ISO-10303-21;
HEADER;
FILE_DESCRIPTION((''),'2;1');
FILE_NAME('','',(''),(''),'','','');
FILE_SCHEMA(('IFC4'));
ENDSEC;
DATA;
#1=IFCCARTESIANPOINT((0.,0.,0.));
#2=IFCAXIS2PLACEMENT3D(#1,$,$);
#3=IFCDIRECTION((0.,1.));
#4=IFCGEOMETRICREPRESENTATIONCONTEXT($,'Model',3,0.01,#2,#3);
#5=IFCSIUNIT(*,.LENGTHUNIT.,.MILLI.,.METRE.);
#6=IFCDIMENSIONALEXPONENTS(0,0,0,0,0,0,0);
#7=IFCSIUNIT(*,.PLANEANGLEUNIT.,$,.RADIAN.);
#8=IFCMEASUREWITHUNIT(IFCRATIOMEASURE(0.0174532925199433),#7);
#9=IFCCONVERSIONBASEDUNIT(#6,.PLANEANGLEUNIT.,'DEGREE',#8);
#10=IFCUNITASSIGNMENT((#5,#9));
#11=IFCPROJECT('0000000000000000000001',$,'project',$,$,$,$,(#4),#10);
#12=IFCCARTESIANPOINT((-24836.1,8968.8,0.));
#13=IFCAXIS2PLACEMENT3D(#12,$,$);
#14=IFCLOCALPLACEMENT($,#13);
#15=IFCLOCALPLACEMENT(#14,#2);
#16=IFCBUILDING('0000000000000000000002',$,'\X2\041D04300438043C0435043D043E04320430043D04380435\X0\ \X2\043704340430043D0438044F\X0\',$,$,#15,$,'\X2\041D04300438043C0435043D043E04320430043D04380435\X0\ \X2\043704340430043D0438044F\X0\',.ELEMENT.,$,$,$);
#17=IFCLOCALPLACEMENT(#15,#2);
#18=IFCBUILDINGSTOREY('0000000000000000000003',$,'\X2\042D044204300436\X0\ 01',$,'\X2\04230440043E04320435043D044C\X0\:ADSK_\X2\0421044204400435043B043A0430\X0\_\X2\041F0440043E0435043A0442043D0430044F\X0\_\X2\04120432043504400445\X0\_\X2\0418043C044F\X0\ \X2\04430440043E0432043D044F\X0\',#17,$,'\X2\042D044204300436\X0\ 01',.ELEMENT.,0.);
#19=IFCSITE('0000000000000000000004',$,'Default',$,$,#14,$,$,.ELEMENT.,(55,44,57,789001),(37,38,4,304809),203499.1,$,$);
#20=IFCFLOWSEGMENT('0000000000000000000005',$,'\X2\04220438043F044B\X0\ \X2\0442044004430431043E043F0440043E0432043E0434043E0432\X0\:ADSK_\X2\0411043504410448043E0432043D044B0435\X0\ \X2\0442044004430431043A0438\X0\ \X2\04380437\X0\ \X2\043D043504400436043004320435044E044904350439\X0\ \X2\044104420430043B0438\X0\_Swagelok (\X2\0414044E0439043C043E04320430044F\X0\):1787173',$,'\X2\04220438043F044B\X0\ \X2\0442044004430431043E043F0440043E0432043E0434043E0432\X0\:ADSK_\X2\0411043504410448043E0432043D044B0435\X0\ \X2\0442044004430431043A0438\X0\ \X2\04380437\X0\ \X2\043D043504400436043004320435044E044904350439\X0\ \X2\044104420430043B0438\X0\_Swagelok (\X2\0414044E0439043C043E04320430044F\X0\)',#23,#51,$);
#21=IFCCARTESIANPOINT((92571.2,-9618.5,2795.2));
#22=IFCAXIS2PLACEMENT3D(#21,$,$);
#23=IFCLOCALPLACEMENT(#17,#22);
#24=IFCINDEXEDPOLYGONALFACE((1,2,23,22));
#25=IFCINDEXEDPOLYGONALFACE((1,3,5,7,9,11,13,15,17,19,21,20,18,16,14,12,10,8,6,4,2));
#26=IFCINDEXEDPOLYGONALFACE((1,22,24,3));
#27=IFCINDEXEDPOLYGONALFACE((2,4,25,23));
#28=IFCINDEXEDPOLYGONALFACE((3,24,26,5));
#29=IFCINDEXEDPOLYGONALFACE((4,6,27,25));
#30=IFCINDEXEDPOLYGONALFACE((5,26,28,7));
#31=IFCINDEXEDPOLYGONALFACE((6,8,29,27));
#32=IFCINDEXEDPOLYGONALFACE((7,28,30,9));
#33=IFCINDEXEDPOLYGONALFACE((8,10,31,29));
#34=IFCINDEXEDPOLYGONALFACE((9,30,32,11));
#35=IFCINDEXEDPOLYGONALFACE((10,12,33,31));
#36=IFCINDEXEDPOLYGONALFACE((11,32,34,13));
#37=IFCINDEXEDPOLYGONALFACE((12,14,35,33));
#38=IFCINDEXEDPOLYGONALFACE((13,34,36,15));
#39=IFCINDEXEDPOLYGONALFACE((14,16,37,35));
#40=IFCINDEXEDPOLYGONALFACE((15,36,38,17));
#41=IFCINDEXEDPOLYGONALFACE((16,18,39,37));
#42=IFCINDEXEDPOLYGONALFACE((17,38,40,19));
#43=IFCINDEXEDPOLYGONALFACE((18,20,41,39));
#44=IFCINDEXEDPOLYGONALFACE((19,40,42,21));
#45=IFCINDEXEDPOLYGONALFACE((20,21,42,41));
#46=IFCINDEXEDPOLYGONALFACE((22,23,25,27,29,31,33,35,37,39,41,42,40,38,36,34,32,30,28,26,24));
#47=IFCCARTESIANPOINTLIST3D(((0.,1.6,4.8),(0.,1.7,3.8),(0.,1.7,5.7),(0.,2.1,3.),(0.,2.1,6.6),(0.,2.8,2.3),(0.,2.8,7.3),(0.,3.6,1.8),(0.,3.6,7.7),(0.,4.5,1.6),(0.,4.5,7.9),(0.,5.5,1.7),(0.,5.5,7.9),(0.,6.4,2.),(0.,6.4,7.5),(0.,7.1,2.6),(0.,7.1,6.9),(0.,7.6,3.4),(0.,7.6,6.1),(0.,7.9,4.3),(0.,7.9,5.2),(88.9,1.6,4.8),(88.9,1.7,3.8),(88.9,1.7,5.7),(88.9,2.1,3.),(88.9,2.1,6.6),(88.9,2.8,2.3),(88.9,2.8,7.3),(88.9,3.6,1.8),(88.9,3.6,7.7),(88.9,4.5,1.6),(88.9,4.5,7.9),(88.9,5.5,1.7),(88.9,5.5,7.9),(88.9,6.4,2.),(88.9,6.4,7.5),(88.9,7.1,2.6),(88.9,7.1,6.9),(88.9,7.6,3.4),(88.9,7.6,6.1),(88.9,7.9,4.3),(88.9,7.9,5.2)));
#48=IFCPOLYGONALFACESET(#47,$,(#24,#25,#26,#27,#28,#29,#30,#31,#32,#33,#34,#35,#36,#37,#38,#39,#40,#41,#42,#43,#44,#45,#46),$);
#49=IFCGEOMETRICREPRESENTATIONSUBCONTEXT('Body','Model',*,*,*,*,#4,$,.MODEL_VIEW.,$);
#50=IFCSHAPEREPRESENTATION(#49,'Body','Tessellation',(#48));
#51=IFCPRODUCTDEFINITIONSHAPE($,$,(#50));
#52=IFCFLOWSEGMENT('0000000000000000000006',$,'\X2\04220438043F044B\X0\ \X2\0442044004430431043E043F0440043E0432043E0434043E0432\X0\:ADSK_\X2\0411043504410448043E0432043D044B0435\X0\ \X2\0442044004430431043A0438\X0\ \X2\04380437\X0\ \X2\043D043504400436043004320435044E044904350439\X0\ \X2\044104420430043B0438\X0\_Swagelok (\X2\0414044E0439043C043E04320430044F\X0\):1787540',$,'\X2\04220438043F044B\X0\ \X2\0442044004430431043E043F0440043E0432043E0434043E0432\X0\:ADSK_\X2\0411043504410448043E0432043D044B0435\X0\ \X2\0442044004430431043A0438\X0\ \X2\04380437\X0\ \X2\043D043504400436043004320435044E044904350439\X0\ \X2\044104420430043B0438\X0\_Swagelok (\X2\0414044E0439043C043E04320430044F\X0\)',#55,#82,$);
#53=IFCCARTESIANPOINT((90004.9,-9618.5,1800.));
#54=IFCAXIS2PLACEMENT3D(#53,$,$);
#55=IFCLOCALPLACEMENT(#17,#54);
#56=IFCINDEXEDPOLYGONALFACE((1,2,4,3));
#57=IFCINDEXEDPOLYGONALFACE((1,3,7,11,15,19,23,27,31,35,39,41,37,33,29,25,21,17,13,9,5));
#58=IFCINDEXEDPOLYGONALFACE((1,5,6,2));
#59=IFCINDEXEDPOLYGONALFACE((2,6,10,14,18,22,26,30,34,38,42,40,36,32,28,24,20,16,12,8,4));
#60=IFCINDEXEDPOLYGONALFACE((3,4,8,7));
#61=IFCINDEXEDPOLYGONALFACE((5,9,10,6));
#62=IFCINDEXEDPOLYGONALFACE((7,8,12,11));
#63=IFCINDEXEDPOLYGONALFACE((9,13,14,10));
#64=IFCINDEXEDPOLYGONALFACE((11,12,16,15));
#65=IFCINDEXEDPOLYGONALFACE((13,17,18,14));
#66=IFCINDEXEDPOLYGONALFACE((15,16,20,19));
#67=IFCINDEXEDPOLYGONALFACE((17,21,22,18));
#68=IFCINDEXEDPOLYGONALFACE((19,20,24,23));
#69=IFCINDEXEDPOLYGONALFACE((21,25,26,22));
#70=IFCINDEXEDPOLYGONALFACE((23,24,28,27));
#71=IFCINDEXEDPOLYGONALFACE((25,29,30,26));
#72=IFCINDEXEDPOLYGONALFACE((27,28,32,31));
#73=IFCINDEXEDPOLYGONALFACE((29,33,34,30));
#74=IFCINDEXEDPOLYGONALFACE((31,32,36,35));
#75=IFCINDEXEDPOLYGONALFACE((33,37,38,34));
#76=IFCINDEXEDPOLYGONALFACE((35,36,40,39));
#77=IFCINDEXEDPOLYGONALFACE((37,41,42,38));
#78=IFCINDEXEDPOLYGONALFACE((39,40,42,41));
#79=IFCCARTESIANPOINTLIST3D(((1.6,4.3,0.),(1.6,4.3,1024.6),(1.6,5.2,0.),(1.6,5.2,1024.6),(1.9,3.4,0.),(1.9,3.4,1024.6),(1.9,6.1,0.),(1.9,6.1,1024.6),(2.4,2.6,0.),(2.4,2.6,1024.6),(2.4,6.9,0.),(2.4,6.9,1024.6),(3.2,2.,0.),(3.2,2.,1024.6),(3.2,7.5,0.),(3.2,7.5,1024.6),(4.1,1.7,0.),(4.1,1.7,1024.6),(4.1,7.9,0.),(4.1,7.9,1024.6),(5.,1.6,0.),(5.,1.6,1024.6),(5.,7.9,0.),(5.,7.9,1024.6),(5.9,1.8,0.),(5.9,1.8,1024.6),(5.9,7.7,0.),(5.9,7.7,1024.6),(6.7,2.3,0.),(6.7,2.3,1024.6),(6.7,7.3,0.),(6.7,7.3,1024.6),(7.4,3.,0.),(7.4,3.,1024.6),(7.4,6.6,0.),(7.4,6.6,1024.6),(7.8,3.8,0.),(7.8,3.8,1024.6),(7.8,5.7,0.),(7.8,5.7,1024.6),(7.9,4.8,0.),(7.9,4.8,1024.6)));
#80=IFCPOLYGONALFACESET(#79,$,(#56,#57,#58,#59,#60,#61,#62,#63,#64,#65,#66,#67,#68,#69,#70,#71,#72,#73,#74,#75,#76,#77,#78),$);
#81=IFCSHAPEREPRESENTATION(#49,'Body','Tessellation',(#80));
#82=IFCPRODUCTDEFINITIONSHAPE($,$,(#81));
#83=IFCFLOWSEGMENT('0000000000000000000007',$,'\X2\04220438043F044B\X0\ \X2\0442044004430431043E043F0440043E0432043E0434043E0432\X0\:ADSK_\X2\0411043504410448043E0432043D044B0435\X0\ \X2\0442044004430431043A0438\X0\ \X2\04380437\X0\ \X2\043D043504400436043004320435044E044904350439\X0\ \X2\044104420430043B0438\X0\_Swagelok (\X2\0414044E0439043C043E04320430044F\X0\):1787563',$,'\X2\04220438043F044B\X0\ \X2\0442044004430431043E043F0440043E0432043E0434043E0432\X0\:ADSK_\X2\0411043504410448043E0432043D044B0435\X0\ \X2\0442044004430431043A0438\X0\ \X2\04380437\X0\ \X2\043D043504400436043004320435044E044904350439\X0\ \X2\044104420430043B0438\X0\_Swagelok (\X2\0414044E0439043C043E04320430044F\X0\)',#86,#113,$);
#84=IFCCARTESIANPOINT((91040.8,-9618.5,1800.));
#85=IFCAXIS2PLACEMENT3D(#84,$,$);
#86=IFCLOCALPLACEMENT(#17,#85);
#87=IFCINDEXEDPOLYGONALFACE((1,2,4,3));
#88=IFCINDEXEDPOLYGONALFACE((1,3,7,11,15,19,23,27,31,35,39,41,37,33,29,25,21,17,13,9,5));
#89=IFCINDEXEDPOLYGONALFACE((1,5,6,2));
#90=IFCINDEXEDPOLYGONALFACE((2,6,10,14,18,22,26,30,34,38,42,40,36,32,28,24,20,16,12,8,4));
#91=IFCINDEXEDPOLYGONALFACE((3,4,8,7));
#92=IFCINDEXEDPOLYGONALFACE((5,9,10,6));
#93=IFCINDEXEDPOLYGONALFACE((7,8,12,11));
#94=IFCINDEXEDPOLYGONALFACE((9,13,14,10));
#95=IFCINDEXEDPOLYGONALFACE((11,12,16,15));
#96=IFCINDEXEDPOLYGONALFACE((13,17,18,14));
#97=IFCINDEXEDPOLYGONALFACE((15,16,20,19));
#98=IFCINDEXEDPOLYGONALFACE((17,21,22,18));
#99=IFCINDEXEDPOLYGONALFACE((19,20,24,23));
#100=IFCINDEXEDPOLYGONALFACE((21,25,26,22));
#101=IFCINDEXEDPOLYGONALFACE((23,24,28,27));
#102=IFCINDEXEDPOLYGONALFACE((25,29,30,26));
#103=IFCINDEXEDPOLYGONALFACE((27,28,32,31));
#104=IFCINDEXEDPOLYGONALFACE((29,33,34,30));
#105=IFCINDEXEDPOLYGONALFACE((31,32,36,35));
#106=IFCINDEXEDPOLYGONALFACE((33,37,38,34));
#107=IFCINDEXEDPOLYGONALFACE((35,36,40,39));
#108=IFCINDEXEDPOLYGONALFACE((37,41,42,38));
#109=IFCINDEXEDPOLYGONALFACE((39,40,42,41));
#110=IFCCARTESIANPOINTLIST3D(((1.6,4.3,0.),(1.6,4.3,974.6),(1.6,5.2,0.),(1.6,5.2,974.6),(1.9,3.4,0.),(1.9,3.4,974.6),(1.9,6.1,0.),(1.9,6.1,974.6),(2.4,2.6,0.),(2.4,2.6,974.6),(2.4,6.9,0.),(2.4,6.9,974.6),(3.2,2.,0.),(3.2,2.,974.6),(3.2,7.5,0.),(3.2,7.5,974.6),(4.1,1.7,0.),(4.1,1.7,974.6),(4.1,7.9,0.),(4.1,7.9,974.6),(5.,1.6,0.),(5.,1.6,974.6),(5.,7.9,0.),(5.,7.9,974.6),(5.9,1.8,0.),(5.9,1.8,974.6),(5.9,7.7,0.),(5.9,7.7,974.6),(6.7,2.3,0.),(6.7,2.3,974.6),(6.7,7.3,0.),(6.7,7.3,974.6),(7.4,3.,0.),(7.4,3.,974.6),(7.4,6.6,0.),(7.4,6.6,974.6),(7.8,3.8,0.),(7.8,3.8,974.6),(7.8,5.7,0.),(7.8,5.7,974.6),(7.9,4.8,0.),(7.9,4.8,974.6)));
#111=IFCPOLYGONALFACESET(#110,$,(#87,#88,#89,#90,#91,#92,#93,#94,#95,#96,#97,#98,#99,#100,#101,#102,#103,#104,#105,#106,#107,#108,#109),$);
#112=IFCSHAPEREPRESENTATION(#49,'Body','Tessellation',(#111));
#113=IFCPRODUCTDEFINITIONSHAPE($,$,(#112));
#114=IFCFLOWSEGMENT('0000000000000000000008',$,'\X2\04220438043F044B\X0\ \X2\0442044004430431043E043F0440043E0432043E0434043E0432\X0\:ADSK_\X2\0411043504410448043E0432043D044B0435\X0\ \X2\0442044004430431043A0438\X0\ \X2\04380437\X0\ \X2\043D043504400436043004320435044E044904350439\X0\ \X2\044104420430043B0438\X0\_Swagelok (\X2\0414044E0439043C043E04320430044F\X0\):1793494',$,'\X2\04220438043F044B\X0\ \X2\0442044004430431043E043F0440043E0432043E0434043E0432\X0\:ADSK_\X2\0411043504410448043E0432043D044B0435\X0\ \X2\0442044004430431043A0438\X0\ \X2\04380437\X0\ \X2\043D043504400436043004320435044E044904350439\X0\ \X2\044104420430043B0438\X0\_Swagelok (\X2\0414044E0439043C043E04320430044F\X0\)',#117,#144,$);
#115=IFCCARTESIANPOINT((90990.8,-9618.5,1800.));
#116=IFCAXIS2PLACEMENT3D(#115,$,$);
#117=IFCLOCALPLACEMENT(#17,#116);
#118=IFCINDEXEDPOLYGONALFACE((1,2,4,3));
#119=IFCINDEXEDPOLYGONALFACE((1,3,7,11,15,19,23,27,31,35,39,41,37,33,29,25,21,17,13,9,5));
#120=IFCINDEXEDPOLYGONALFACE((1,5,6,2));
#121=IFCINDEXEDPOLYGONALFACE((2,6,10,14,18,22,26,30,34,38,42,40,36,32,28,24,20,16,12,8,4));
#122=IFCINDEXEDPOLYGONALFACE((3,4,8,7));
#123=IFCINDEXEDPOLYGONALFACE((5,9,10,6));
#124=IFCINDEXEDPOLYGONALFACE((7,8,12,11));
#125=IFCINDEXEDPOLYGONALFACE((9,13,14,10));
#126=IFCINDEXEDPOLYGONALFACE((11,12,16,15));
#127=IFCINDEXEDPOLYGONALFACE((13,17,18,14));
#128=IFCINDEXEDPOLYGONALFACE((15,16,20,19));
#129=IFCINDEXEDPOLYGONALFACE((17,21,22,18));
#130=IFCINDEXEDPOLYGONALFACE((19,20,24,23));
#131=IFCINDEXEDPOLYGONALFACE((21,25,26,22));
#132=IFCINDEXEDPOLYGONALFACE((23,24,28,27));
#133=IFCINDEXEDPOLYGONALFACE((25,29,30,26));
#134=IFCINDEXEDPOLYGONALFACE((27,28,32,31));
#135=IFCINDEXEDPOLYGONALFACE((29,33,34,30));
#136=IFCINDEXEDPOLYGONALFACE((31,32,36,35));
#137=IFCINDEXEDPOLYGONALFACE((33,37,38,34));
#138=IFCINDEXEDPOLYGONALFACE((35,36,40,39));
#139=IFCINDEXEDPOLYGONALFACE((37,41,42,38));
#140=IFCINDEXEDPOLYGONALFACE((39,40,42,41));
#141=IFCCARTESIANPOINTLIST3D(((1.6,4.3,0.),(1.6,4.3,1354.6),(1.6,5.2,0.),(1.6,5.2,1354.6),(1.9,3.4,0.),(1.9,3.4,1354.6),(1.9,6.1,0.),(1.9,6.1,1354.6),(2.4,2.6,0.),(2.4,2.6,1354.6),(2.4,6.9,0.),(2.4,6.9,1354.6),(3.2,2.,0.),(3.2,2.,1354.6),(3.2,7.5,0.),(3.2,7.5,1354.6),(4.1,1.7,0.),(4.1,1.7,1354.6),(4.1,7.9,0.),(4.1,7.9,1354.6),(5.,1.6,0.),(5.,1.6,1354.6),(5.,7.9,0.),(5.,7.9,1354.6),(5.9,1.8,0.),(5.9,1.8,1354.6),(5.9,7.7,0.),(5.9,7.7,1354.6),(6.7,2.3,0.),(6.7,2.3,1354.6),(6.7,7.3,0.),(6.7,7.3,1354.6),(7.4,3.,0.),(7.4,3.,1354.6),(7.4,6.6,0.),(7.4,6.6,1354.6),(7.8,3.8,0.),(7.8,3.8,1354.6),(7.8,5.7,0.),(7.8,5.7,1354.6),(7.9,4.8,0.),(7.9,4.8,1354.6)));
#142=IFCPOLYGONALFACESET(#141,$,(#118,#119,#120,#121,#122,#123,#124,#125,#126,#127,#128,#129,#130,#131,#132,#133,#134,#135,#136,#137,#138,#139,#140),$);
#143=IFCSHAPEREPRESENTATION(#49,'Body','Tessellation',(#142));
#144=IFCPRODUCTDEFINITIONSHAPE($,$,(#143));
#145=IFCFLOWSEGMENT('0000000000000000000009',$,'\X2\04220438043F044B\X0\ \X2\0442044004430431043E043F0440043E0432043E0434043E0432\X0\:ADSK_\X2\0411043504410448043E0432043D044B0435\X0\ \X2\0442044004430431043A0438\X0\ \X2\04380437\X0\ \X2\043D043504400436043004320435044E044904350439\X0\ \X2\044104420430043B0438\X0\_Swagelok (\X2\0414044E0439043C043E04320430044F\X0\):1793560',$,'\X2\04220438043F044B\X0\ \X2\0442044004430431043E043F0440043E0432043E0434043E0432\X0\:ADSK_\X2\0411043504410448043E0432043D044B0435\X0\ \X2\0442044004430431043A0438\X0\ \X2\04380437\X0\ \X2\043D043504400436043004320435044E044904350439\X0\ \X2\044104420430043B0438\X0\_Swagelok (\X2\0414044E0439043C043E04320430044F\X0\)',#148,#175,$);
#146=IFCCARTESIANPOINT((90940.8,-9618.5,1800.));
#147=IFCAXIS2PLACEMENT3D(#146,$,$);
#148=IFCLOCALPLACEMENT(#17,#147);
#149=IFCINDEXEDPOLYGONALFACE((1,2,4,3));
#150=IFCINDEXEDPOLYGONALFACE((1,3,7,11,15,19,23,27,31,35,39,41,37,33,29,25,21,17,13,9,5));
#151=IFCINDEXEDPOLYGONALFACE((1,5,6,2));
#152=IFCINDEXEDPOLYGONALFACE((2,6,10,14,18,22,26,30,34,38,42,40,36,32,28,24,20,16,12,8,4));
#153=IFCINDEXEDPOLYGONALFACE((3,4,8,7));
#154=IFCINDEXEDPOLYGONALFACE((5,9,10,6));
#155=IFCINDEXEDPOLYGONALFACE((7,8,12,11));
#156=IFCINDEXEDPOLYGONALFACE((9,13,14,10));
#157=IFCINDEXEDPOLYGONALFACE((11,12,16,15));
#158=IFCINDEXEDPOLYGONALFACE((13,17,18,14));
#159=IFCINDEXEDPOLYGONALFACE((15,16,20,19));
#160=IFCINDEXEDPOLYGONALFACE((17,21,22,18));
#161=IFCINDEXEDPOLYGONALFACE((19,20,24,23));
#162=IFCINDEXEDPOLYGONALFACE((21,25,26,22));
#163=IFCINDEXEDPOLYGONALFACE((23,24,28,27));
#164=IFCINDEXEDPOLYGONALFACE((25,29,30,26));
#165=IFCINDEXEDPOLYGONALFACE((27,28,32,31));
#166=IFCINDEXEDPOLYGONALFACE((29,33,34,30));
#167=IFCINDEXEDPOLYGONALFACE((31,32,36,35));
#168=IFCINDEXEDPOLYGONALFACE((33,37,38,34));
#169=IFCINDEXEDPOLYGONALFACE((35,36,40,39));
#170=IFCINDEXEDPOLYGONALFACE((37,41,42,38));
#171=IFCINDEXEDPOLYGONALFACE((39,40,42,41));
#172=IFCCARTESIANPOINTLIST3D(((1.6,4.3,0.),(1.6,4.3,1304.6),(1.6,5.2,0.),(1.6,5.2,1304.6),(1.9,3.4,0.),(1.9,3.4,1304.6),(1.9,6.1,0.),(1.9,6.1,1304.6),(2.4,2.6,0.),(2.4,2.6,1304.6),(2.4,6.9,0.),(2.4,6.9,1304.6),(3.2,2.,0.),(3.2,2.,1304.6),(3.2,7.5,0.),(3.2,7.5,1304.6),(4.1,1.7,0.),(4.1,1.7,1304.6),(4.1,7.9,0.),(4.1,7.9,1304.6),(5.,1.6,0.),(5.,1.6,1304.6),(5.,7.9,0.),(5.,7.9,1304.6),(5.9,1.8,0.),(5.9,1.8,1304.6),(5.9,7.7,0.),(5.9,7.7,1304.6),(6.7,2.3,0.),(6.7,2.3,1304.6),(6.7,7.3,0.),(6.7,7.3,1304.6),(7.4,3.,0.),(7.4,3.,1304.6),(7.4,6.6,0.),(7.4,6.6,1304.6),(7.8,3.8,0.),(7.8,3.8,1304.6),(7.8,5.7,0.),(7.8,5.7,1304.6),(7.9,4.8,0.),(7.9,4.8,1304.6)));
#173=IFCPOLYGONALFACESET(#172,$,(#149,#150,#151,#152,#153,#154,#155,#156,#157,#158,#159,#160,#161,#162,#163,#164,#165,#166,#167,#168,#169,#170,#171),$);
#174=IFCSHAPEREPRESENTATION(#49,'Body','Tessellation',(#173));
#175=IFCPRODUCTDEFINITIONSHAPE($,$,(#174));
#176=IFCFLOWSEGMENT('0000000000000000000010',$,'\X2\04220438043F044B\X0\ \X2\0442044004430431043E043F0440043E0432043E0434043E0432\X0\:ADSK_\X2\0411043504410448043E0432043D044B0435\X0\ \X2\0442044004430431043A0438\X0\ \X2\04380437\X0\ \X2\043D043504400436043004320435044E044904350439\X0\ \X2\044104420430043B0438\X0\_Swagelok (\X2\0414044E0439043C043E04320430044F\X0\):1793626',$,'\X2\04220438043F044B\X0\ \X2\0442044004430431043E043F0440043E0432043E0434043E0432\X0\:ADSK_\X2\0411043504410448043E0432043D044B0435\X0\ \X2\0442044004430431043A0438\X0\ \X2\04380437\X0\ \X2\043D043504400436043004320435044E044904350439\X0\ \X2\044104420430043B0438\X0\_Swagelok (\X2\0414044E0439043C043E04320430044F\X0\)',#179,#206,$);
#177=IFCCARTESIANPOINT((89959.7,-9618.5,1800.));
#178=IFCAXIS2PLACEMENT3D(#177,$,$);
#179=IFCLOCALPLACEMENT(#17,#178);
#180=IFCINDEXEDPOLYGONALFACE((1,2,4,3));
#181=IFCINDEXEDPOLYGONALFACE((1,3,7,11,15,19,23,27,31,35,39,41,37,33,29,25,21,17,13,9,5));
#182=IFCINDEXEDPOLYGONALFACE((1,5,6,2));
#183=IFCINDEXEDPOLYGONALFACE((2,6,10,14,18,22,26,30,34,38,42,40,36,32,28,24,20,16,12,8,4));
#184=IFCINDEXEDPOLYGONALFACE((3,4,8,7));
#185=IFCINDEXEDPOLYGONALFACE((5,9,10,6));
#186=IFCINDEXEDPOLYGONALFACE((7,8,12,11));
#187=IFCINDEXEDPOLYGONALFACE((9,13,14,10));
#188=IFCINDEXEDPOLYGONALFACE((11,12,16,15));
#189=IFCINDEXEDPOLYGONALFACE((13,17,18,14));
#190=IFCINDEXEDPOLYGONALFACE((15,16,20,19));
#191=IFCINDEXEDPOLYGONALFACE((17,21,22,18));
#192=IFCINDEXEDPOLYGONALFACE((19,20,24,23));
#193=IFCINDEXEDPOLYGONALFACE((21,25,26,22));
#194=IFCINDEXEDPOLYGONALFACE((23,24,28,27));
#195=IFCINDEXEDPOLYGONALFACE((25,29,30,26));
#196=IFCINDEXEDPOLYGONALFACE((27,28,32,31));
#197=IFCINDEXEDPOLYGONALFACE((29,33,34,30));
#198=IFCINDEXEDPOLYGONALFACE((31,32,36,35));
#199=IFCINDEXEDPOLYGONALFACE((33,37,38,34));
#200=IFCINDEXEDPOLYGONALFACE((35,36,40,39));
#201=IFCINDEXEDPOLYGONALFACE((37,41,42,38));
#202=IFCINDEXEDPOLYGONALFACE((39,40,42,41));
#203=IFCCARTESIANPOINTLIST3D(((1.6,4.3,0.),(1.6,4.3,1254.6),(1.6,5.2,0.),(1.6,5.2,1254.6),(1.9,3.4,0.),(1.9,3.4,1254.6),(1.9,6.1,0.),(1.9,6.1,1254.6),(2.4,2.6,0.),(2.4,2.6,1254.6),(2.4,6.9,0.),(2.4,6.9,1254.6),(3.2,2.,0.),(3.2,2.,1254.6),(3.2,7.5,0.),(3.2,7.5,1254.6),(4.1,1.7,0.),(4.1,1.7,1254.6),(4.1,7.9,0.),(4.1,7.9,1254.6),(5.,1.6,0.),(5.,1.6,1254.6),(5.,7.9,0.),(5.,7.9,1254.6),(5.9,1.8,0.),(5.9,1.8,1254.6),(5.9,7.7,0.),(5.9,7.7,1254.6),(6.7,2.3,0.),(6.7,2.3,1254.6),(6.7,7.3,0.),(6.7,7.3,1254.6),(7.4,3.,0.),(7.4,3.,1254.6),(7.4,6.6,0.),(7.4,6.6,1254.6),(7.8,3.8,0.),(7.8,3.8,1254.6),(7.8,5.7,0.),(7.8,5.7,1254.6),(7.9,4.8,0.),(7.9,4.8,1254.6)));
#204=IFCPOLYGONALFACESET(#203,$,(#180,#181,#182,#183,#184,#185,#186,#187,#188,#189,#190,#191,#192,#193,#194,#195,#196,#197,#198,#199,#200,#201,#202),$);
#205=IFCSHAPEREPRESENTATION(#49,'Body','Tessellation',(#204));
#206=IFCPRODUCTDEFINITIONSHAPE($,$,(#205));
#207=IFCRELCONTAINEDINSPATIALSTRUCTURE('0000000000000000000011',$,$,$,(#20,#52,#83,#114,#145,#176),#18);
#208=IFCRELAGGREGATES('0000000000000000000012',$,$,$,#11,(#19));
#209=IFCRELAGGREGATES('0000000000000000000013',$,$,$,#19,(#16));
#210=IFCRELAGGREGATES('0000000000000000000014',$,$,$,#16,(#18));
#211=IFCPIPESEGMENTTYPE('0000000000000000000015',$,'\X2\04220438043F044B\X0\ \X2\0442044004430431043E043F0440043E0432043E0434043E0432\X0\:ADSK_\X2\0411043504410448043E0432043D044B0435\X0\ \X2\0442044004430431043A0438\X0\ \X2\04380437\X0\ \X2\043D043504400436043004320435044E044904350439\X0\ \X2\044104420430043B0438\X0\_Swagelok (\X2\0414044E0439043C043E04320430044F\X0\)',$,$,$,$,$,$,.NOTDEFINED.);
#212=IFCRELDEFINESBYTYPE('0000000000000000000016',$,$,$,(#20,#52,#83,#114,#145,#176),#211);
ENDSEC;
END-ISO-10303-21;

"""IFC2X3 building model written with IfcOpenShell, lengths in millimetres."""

from ifc_helpers import new_model, entity, si_unit, converted_unit, direction, frame, origin, origin_2d_with_axis, place, context, subcontext, project, spatial, circle, extrude, type_object, element, save


model = new_model("IFC2X3")

# Units and contexts
model_context = context("Model", 3, precision=0.01, world=origin(), true_north=direction((0.0, 1.0)))
body_context = subcontext(model_context, "Body", "Model", "MODEL_VIEW")
ifc_project = project(units=[si_unit("LENGTHUNIT", "METRE", prefix="MILLI"), converted_unit("PLANEANGLEUNIT", "DEGREE", entity("IfcRatioMeasure", 0.0174532925199433), si_unit("PLANEANGLEUNIT", "RADIAN"), dimensions=[0, 0, 0, 0, 0, 0, 0])], contexts=[model_context])

# Site, building, storey
site_placement = place(None, frame((-24836.1, 8968.8, 0.0)))
site = spatial("IfcSite", under=ifc_project, at=site_placement, Name="Default", CompositionType="ELEMENT", RefLatitude=(55, 44, 57, 789001), RefLongitude=(37, 38, 4, 304809), RefElevation=203499.1)
building_placement = place(site_placement, origin())
building = spatial("IfcBuilding", under=site, at=building_placement, Name="Наименование здания", LongName="Наименование здания", CompositionType="ELEMENT")
storey_placement = place(building_placement, origin())
storey = spatial("IfcBuildingStorey", under=building, at=storey_placement, Name="Этаж 01", ObjectType="Уровень:ADSK_Стрелка_Проектная_Вверх_Имя уровня", LongName="Этаж 01", CompositionType="ELEMENT", Elevation=0.0)

# Flow segments
pipe_segment_type_1 = type_object("IfcPipeSegmentType", Name="Типы трубопроводов:ADSK_Бесшовные трубки из нержавеющей стали_Swagelok (Дюймовая)", PredefinedType="NOTDEFINED")
flow_segment_1_placement = place(storey_placement, frame((92571.2, -9618.5, 2795.2)))
element("IfcFlowSegment", 1, at=flow_segment_1_placement, inside=storey, type_object=pipe_segment_type_1, Name="Типы трубопроводов:ADSK_Бесшовные трубки из нержавеющей стали_Swagelok (Дюймовая):1787173", ObjectType="Типы трубопроводов:ADSK_Бесшовные трубки из нержавеющей стали_Swagelok (Дюймовая)", context=body_context, shape_type="SweptSolid", body=[
    extrude(circle(Radius=3.2, at=origin_2d_with_axis()), frame((0.0, 4.8, 4.8), z_axis=(1.0, 0.0, 0.0), x_axis=(0.0, -1.0, 0.0)), (0.0, 0.0, 1.0), 88.9),
])
flow_segment_2_placement = place(storey_placement, frame((90004.9, -9618.5, 1800.0)))
element("IfcFlowSegment", 2, at=flow_segment_2_placement, inside=storey, type_object=pipe_segment_type_1, Name="Типы трубопроводов:ADSK_Бесшовные трубки из нержавеющей стали_Swagelok (Дюймовая):1787540", ObjectType="Типы трубопроводов:ADSK_Бесшовные трубки из нержавеющей стали_Swagelok (Дюймовая)", context=body_context, shape_type="SweptSolid", body=[
    extrude(circle(Radius=3.2, at=origin_2d_with_axis()), frame((4.8, 4.8, 0.0)), (0.0, 0.0, 1.0), 1024.6),
])
flow_segment_3_placement = place(storey_placement, frame((91040.8, -9618.5, 1800.0)))
element("IfcFlowSegment", 3, at=flow_segment_3_placement, inside=storey, type_object=pipe_segment_type_1, Name="Типы трубопроводов:ADSK_Бесшовные трубки из нержавеющей стали_Swagelok (Дюймовая):1787563", ObjectType="Типы трубопроводов:ADSK_Бесшовные трубки из нержавеющей стали_Swagelok (Дюймовая)", context=body_context, shape_type="SweptSolid", body=[
    extrude(circle(Radius=3.2, at=origin_2d_with_axis()), frame((4.8, 4.8, 0.0)), (0.0, 0.0, 1.0), 974.6),
])
flow_segment_4_placement = place(storey_placement, frame((90990.8, -9618.5, 1800.0)))
element("IfcFlowSegment", 4, at=flow_segment_4_placement, inside=storey, type_object=pipe_segment_type_1, Name="Типы трубопроводов:ADSK_Бесшовные трубки из нержавеющей стали_Swagelok (Дюймовая):1793494", ObjectType="Типы трубопроводов:ADSK_Бесшовные трубки из нержавеющей стали_Swagelok (Дюймовая)", context=body_context, shape_type="SweptSolid", body=[
    extrude(circle(Radius=3.2, at=origin_2d_with_axis()), frame((4.8, 4.8, 0.0)), (0.0, 0.0, 1.0), 1354.6),
])
flow_segment_5_placement = place(storey_placement, frame((90940.8, -9618.5, 1800.0)))
element("IfcFlowSegment", 5, at=flow_segment_5_placement, inside=storey, type_object=pipe_segment_type_1, Name="Типы трубопроводов:ADSK_Бесшовные трубки из нержавеющей стали_Swagelok (Дюймовая):1793560", ObjectType="Типы трубопроводов:ADSK_Бесшовные трубки из нержавеющей стали_Swagelok (Дюймовая)", context=body_context, shape_type="SweptSolid", body=[
    extrude(circle(Radius=3.2, at=origin_2d_with_axis()), frame((4.8, 4.8, 0.0)), (0.0, 0.0, 1.0), 1304.6),
])
flow_segment_6_placement = place(storey_placement, frame((89959.7, -9618.5, 1800.0)))
element("IfcFlowSegment", 6, at=flow_segment_6_placement, inside=storey, type_object=pipe_segment_type_1, Name="Типы трубопроводов:ADSK_Бесшовные трубки из нержавеющей стали_Swagelok (Дюймовая):1793626", ObjectType="Типы трубопроводов:ADSK_Бесшовные трубки из нержавеющей стали_Swagelok (Дюймовая)", context=body_context, shape_type="SweptSolid", body=[
    extrude(circle(Radius=3.2, at=origin_2d_with_axis()), frame((4.8, 4.8, 0.0)), (0.0, 0.0, 1.0), 1254.6),
])

save(model, "model.ifc")
